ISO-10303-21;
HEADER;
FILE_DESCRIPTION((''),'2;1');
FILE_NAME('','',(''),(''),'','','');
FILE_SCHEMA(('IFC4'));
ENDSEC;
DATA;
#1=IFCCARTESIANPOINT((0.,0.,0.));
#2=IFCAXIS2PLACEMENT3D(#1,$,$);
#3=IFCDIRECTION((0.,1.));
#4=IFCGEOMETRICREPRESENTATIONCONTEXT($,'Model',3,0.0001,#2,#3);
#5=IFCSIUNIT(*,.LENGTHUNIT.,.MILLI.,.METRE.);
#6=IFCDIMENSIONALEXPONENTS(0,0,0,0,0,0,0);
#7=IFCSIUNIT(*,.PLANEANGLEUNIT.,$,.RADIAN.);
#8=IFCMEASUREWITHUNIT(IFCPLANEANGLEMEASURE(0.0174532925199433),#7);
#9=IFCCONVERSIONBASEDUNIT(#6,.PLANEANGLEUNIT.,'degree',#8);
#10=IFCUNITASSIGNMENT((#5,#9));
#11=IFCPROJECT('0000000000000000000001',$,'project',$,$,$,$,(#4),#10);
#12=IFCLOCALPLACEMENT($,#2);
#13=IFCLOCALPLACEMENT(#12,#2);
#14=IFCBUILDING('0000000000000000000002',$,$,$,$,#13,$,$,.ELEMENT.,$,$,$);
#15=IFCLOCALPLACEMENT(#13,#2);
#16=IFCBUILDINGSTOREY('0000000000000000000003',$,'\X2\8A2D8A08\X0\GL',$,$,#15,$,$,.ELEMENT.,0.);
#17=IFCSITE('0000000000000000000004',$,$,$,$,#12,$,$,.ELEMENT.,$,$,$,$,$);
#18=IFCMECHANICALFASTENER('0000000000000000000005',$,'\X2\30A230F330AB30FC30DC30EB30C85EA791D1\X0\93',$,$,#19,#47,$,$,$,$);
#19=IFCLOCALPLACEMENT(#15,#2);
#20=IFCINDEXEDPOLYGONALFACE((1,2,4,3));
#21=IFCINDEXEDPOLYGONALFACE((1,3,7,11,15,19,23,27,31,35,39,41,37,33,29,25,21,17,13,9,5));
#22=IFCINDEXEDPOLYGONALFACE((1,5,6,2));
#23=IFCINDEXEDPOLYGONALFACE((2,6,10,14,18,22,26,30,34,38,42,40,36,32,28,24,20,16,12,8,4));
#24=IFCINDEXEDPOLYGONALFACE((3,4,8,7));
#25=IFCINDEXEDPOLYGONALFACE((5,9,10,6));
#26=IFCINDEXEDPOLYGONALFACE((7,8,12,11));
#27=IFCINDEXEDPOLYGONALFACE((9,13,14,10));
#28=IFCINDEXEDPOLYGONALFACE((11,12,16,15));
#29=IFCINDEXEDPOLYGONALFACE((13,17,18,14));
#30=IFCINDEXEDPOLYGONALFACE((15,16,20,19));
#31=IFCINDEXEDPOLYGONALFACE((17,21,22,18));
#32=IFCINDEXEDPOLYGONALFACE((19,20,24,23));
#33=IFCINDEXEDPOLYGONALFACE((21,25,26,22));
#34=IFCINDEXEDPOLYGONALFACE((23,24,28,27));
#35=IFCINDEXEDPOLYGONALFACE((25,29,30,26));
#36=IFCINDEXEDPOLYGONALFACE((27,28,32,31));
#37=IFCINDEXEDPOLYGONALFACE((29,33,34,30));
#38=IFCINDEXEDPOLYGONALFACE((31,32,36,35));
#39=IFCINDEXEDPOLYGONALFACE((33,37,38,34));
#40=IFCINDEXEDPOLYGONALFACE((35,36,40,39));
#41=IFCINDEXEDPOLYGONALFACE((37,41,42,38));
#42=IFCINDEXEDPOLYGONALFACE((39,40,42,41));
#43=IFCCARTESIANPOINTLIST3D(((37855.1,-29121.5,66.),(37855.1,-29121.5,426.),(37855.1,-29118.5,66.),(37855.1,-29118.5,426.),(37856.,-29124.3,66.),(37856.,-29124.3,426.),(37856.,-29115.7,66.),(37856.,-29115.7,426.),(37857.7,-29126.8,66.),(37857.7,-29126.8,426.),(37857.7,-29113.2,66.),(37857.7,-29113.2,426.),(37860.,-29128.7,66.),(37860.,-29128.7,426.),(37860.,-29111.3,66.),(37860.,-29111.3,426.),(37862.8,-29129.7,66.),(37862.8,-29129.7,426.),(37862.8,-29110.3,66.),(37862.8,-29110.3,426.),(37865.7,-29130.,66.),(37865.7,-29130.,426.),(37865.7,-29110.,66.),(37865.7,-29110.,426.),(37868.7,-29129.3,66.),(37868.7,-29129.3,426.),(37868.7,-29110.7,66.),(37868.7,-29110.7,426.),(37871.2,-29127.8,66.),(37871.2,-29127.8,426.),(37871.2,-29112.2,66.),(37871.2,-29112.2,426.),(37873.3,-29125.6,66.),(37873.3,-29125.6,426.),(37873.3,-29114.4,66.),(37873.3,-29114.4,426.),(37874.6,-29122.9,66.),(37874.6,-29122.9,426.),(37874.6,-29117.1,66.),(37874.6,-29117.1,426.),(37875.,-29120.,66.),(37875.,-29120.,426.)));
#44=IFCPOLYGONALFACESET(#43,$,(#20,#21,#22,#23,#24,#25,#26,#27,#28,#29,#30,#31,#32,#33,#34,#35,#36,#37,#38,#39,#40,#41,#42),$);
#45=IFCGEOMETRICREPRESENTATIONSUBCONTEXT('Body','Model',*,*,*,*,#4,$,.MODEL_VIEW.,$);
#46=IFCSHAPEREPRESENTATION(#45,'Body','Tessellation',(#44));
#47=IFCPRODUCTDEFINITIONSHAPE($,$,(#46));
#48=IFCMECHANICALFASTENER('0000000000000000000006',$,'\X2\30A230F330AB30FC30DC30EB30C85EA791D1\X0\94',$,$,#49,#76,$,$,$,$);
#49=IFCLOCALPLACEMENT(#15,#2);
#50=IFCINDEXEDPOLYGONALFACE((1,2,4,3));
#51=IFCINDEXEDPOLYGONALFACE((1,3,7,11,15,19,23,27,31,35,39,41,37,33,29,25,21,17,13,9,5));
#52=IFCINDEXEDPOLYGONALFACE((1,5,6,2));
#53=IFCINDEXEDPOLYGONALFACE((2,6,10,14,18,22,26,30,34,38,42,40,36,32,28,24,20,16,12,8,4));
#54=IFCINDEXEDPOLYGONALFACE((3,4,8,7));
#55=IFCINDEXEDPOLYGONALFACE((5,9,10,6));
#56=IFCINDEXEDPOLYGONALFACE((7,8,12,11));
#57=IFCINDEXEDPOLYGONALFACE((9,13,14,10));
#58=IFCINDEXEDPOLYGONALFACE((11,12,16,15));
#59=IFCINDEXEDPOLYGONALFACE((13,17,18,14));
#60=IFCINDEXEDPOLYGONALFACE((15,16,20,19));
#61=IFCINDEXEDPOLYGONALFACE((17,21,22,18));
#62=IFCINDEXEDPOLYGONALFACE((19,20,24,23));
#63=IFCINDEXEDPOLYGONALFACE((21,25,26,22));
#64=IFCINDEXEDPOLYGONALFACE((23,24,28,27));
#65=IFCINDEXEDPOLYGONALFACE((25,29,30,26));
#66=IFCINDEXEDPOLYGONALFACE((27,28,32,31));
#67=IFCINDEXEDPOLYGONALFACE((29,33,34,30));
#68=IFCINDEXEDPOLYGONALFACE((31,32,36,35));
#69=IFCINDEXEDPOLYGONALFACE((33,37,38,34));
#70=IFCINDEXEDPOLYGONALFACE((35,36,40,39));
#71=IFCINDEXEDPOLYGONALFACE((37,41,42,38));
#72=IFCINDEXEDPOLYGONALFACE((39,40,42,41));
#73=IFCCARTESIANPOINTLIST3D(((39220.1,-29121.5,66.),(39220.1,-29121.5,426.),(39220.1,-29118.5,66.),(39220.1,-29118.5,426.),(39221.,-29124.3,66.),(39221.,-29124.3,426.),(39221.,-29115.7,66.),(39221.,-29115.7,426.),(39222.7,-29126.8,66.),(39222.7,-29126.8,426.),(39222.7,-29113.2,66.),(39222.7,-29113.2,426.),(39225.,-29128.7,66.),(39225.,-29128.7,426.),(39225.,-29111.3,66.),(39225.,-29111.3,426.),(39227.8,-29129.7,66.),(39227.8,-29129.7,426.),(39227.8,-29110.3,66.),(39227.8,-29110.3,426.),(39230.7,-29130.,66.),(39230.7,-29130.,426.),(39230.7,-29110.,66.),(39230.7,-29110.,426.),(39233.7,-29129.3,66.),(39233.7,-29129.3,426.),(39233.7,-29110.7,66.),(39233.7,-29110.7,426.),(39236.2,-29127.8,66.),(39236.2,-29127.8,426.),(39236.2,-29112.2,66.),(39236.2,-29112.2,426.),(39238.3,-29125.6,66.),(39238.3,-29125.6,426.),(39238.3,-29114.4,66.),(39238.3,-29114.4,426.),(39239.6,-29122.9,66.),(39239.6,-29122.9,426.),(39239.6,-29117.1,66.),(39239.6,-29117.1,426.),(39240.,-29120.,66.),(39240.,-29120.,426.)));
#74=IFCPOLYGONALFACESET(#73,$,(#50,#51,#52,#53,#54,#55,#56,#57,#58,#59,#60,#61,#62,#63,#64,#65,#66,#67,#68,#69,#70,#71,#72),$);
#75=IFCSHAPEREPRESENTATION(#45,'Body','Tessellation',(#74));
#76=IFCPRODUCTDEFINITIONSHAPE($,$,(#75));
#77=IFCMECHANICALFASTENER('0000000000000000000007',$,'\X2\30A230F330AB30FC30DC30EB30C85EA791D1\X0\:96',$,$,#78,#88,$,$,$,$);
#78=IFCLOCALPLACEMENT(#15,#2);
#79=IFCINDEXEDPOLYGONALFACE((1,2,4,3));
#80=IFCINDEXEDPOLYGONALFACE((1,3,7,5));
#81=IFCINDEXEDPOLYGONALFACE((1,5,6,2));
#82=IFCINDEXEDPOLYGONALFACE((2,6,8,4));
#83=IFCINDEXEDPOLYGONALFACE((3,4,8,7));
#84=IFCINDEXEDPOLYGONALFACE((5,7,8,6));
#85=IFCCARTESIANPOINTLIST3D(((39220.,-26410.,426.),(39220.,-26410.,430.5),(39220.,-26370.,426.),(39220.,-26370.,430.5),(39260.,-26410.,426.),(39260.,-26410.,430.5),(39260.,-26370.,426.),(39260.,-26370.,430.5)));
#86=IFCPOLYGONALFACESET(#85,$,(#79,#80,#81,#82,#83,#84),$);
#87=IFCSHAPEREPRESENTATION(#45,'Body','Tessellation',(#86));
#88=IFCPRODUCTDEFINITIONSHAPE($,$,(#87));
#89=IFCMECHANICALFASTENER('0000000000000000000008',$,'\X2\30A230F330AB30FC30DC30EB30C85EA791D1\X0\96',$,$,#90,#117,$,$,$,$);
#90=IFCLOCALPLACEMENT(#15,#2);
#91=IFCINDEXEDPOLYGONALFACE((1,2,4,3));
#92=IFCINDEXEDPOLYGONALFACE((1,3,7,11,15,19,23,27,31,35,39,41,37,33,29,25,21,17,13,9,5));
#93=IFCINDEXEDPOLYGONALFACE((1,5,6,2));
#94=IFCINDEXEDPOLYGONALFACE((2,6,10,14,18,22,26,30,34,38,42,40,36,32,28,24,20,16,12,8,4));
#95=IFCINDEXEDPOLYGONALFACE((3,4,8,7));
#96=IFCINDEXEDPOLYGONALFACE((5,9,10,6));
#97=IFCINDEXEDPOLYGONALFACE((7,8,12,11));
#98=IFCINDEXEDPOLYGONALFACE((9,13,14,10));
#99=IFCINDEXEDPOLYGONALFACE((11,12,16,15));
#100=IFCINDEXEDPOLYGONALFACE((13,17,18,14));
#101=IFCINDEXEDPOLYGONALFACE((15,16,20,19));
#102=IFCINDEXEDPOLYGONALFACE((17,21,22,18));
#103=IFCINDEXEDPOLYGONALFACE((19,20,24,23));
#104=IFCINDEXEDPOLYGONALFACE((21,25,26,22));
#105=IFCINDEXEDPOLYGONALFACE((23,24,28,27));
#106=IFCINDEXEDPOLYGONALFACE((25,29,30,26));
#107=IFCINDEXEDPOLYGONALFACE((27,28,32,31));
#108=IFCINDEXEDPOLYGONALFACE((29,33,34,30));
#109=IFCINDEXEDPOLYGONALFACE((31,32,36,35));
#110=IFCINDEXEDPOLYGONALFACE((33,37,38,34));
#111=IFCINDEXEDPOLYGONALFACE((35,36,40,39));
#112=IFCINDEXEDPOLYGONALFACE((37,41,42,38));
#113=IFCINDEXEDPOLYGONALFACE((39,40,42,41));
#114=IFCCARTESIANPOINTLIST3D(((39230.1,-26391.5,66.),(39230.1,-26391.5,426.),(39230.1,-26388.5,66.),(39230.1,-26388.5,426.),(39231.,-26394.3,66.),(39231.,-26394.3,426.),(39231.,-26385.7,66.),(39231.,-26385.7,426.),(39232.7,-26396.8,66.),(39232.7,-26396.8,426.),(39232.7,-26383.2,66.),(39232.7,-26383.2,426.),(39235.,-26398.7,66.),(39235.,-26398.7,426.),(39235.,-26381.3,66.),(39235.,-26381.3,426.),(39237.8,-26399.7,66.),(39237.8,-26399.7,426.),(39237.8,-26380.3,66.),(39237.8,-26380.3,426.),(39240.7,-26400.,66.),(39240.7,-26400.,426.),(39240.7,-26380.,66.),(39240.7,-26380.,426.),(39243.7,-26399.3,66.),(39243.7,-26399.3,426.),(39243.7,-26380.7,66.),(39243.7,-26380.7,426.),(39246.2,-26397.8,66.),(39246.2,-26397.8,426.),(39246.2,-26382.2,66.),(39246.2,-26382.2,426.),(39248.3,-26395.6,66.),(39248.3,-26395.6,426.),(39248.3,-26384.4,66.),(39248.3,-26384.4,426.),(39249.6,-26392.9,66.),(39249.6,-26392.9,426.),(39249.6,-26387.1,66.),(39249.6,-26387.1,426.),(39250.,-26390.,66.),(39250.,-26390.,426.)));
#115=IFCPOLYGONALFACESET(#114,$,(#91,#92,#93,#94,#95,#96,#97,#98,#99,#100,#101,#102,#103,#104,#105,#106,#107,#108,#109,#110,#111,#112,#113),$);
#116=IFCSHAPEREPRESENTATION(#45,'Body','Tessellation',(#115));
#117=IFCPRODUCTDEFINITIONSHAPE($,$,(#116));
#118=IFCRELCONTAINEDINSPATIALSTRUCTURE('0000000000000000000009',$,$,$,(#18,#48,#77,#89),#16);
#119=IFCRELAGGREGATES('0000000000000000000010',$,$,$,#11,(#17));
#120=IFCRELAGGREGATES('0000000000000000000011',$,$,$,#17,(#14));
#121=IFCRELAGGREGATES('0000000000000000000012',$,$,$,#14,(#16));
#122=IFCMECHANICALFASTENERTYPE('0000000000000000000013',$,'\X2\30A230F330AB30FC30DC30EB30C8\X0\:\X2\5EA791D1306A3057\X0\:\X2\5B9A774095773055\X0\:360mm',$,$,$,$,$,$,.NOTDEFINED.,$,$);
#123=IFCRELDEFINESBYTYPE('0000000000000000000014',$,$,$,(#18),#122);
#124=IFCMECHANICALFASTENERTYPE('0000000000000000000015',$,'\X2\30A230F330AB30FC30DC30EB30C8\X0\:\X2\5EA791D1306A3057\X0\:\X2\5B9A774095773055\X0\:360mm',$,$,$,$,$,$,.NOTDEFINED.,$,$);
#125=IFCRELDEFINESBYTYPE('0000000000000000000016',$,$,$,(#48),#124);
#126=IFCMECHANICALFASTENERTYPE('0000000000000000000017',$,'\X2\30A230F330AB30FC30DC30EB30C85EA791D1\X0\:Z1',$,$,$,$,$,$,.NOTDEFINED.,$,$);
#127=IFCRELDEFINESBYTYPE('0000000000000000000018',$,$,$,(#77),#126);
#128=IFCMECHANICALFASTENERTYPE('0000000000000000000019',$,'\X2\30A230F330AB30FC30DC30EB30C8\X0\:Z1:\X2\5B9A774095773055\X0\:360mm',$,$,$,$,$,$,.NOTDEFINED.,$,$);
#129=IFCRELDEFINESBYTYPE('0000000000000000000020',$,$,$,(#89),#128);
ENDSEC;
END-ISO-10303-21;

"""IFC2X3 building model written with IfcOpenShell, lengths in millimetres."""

from ifc_helpers import new_model, entity, si_unit, converted_unit, direction, frame, origin, origin_with_axes, origin_2d, place, context, subcontext, project, spatial, rectangle, circle, extrude, type_object, element, save


model = new_model("IFC2X3")

# Units and contexts
model_context = context("Model", 3, precision=0.0001, world=origin(), true_north=direction((0.0, 1.0)))
body_context = subcontext(model_context, "Body", "Model", "MODEL_VIEW")
ifc_project = project(units=[si_unit("LENGTHUNIT", "METRE", prefix="MILLI"), converted_unit("PLANEANGLEUNIT", "degree", entity("IfcPlaneAngleMeasure", 0.0174532925199433), si_unit("PLANEANGLEUNIT", "RADIAN"), dimensions=[0, 0, 0, 0, 0, 0, 0])], contexts=[model_context])

# Site, building, storey
site_placement = place(None, origin())
site = spatial("IfcSite", under=ifc_project, at=site_placement, CompositionType="ELEMENT")
building_placement = place(site_placement, origin())
building = spatial("IfcBuilding", under=site, at=building_placement, CompositionType="ELEMENT")
storey_placement = place(building_placement, origin())
storey = spatial("IfcBuildingStorey", under=building, at=storey_placement, Name="設計GL", CompositionType="ELEMENT", Elevation=0.0)

# Mechanical fasteners
mechanical_fastener_type_1 = type_object("IfcMechanicalFastenerType", Name="アンカーボルト:座金なし:定着長さ:360mm")
mechanical_fastener_1_placement = place(storey_placement, frame((37865.0, -29120.0, 66.0)))
element("IfcMechanicalFastener", 1, at=mechanical_fastener_1_placement, inside=storey, type_object=mechanical_fastener_type_1, Name="アンカーボルト座金93", context=body_context, shape_type="SweptSolid", body=[
    extrude(circle(Radius=10.0, at=origin_2d()), origin_with_axes(), (0.0, 0.0, 1.0), 360.0),
])
mechanical_fastener_type_2 = type_object("IfcMechanicalFastenerType", Name="アンカーボルト:座金なし:定着長さ:360mm")
mechanical_fastener_2_placement = place(storey_placement, frame((39230.0, -29120.0, 66.0)))
element("IfcMechanicalFastener", 2, at=mechanical_fastener_2_placement, inside=storey, type_object=mechanical_fastener_type_2, Name="アンカーボルト座金94", context=body_context, shape_type="SweptSolid", body=[
    extrude(circle(Radius=10.0, at=origin_2d()), origin_with_axes(), (0.0, 0.0, 1.0), 360.0),
])
mechanical_fastener_type_3 = type_object("IfcMechanicalFastenerType", Name="アンカーボルト座金:Z1")
mechanical_fastener_3_placement = place(storey_placement, frame((39240.0, -26390.0, 426.0)))
element("IfcMechanicalFastener", 3, at=mechanical_fastener_3_placement, inside=storey, type_object=mechanical_fastener_type_3, Name="アンカーボルト座金:96", context=body_context, shape_type="SweptSolid", body=[
    extrude(rectangle(XDim=40.0, YDim=40.0, at=origin_2d()), origin_with_axes(), (0.0, 0.0, 1.0), 4.5),
])
mechanical_fastener_type_4 = type_object("IfcMechanicalFastenerType", Name="アンカーボルト:Z1:定着長さ:360mm")
mechanical_fastener_4_placement = place(storey_placement, frame((39240.0, -26390.0, 66.0)))
element("IfcMechanicalFastener", 4, at=mechanical_fastener_4_placement, inside=storey, type_object=mechanical_fastener_type_4, Name="アンカーボルト座金96", context=body_context, shape_type="SweptSolid", body=[
    extrude(circle(Radius=10.0, at=origin_2d()), origin_with_axes(), (0.0, 0.0, 1.0), 360.0),
])

save(model, "model.ifc")
